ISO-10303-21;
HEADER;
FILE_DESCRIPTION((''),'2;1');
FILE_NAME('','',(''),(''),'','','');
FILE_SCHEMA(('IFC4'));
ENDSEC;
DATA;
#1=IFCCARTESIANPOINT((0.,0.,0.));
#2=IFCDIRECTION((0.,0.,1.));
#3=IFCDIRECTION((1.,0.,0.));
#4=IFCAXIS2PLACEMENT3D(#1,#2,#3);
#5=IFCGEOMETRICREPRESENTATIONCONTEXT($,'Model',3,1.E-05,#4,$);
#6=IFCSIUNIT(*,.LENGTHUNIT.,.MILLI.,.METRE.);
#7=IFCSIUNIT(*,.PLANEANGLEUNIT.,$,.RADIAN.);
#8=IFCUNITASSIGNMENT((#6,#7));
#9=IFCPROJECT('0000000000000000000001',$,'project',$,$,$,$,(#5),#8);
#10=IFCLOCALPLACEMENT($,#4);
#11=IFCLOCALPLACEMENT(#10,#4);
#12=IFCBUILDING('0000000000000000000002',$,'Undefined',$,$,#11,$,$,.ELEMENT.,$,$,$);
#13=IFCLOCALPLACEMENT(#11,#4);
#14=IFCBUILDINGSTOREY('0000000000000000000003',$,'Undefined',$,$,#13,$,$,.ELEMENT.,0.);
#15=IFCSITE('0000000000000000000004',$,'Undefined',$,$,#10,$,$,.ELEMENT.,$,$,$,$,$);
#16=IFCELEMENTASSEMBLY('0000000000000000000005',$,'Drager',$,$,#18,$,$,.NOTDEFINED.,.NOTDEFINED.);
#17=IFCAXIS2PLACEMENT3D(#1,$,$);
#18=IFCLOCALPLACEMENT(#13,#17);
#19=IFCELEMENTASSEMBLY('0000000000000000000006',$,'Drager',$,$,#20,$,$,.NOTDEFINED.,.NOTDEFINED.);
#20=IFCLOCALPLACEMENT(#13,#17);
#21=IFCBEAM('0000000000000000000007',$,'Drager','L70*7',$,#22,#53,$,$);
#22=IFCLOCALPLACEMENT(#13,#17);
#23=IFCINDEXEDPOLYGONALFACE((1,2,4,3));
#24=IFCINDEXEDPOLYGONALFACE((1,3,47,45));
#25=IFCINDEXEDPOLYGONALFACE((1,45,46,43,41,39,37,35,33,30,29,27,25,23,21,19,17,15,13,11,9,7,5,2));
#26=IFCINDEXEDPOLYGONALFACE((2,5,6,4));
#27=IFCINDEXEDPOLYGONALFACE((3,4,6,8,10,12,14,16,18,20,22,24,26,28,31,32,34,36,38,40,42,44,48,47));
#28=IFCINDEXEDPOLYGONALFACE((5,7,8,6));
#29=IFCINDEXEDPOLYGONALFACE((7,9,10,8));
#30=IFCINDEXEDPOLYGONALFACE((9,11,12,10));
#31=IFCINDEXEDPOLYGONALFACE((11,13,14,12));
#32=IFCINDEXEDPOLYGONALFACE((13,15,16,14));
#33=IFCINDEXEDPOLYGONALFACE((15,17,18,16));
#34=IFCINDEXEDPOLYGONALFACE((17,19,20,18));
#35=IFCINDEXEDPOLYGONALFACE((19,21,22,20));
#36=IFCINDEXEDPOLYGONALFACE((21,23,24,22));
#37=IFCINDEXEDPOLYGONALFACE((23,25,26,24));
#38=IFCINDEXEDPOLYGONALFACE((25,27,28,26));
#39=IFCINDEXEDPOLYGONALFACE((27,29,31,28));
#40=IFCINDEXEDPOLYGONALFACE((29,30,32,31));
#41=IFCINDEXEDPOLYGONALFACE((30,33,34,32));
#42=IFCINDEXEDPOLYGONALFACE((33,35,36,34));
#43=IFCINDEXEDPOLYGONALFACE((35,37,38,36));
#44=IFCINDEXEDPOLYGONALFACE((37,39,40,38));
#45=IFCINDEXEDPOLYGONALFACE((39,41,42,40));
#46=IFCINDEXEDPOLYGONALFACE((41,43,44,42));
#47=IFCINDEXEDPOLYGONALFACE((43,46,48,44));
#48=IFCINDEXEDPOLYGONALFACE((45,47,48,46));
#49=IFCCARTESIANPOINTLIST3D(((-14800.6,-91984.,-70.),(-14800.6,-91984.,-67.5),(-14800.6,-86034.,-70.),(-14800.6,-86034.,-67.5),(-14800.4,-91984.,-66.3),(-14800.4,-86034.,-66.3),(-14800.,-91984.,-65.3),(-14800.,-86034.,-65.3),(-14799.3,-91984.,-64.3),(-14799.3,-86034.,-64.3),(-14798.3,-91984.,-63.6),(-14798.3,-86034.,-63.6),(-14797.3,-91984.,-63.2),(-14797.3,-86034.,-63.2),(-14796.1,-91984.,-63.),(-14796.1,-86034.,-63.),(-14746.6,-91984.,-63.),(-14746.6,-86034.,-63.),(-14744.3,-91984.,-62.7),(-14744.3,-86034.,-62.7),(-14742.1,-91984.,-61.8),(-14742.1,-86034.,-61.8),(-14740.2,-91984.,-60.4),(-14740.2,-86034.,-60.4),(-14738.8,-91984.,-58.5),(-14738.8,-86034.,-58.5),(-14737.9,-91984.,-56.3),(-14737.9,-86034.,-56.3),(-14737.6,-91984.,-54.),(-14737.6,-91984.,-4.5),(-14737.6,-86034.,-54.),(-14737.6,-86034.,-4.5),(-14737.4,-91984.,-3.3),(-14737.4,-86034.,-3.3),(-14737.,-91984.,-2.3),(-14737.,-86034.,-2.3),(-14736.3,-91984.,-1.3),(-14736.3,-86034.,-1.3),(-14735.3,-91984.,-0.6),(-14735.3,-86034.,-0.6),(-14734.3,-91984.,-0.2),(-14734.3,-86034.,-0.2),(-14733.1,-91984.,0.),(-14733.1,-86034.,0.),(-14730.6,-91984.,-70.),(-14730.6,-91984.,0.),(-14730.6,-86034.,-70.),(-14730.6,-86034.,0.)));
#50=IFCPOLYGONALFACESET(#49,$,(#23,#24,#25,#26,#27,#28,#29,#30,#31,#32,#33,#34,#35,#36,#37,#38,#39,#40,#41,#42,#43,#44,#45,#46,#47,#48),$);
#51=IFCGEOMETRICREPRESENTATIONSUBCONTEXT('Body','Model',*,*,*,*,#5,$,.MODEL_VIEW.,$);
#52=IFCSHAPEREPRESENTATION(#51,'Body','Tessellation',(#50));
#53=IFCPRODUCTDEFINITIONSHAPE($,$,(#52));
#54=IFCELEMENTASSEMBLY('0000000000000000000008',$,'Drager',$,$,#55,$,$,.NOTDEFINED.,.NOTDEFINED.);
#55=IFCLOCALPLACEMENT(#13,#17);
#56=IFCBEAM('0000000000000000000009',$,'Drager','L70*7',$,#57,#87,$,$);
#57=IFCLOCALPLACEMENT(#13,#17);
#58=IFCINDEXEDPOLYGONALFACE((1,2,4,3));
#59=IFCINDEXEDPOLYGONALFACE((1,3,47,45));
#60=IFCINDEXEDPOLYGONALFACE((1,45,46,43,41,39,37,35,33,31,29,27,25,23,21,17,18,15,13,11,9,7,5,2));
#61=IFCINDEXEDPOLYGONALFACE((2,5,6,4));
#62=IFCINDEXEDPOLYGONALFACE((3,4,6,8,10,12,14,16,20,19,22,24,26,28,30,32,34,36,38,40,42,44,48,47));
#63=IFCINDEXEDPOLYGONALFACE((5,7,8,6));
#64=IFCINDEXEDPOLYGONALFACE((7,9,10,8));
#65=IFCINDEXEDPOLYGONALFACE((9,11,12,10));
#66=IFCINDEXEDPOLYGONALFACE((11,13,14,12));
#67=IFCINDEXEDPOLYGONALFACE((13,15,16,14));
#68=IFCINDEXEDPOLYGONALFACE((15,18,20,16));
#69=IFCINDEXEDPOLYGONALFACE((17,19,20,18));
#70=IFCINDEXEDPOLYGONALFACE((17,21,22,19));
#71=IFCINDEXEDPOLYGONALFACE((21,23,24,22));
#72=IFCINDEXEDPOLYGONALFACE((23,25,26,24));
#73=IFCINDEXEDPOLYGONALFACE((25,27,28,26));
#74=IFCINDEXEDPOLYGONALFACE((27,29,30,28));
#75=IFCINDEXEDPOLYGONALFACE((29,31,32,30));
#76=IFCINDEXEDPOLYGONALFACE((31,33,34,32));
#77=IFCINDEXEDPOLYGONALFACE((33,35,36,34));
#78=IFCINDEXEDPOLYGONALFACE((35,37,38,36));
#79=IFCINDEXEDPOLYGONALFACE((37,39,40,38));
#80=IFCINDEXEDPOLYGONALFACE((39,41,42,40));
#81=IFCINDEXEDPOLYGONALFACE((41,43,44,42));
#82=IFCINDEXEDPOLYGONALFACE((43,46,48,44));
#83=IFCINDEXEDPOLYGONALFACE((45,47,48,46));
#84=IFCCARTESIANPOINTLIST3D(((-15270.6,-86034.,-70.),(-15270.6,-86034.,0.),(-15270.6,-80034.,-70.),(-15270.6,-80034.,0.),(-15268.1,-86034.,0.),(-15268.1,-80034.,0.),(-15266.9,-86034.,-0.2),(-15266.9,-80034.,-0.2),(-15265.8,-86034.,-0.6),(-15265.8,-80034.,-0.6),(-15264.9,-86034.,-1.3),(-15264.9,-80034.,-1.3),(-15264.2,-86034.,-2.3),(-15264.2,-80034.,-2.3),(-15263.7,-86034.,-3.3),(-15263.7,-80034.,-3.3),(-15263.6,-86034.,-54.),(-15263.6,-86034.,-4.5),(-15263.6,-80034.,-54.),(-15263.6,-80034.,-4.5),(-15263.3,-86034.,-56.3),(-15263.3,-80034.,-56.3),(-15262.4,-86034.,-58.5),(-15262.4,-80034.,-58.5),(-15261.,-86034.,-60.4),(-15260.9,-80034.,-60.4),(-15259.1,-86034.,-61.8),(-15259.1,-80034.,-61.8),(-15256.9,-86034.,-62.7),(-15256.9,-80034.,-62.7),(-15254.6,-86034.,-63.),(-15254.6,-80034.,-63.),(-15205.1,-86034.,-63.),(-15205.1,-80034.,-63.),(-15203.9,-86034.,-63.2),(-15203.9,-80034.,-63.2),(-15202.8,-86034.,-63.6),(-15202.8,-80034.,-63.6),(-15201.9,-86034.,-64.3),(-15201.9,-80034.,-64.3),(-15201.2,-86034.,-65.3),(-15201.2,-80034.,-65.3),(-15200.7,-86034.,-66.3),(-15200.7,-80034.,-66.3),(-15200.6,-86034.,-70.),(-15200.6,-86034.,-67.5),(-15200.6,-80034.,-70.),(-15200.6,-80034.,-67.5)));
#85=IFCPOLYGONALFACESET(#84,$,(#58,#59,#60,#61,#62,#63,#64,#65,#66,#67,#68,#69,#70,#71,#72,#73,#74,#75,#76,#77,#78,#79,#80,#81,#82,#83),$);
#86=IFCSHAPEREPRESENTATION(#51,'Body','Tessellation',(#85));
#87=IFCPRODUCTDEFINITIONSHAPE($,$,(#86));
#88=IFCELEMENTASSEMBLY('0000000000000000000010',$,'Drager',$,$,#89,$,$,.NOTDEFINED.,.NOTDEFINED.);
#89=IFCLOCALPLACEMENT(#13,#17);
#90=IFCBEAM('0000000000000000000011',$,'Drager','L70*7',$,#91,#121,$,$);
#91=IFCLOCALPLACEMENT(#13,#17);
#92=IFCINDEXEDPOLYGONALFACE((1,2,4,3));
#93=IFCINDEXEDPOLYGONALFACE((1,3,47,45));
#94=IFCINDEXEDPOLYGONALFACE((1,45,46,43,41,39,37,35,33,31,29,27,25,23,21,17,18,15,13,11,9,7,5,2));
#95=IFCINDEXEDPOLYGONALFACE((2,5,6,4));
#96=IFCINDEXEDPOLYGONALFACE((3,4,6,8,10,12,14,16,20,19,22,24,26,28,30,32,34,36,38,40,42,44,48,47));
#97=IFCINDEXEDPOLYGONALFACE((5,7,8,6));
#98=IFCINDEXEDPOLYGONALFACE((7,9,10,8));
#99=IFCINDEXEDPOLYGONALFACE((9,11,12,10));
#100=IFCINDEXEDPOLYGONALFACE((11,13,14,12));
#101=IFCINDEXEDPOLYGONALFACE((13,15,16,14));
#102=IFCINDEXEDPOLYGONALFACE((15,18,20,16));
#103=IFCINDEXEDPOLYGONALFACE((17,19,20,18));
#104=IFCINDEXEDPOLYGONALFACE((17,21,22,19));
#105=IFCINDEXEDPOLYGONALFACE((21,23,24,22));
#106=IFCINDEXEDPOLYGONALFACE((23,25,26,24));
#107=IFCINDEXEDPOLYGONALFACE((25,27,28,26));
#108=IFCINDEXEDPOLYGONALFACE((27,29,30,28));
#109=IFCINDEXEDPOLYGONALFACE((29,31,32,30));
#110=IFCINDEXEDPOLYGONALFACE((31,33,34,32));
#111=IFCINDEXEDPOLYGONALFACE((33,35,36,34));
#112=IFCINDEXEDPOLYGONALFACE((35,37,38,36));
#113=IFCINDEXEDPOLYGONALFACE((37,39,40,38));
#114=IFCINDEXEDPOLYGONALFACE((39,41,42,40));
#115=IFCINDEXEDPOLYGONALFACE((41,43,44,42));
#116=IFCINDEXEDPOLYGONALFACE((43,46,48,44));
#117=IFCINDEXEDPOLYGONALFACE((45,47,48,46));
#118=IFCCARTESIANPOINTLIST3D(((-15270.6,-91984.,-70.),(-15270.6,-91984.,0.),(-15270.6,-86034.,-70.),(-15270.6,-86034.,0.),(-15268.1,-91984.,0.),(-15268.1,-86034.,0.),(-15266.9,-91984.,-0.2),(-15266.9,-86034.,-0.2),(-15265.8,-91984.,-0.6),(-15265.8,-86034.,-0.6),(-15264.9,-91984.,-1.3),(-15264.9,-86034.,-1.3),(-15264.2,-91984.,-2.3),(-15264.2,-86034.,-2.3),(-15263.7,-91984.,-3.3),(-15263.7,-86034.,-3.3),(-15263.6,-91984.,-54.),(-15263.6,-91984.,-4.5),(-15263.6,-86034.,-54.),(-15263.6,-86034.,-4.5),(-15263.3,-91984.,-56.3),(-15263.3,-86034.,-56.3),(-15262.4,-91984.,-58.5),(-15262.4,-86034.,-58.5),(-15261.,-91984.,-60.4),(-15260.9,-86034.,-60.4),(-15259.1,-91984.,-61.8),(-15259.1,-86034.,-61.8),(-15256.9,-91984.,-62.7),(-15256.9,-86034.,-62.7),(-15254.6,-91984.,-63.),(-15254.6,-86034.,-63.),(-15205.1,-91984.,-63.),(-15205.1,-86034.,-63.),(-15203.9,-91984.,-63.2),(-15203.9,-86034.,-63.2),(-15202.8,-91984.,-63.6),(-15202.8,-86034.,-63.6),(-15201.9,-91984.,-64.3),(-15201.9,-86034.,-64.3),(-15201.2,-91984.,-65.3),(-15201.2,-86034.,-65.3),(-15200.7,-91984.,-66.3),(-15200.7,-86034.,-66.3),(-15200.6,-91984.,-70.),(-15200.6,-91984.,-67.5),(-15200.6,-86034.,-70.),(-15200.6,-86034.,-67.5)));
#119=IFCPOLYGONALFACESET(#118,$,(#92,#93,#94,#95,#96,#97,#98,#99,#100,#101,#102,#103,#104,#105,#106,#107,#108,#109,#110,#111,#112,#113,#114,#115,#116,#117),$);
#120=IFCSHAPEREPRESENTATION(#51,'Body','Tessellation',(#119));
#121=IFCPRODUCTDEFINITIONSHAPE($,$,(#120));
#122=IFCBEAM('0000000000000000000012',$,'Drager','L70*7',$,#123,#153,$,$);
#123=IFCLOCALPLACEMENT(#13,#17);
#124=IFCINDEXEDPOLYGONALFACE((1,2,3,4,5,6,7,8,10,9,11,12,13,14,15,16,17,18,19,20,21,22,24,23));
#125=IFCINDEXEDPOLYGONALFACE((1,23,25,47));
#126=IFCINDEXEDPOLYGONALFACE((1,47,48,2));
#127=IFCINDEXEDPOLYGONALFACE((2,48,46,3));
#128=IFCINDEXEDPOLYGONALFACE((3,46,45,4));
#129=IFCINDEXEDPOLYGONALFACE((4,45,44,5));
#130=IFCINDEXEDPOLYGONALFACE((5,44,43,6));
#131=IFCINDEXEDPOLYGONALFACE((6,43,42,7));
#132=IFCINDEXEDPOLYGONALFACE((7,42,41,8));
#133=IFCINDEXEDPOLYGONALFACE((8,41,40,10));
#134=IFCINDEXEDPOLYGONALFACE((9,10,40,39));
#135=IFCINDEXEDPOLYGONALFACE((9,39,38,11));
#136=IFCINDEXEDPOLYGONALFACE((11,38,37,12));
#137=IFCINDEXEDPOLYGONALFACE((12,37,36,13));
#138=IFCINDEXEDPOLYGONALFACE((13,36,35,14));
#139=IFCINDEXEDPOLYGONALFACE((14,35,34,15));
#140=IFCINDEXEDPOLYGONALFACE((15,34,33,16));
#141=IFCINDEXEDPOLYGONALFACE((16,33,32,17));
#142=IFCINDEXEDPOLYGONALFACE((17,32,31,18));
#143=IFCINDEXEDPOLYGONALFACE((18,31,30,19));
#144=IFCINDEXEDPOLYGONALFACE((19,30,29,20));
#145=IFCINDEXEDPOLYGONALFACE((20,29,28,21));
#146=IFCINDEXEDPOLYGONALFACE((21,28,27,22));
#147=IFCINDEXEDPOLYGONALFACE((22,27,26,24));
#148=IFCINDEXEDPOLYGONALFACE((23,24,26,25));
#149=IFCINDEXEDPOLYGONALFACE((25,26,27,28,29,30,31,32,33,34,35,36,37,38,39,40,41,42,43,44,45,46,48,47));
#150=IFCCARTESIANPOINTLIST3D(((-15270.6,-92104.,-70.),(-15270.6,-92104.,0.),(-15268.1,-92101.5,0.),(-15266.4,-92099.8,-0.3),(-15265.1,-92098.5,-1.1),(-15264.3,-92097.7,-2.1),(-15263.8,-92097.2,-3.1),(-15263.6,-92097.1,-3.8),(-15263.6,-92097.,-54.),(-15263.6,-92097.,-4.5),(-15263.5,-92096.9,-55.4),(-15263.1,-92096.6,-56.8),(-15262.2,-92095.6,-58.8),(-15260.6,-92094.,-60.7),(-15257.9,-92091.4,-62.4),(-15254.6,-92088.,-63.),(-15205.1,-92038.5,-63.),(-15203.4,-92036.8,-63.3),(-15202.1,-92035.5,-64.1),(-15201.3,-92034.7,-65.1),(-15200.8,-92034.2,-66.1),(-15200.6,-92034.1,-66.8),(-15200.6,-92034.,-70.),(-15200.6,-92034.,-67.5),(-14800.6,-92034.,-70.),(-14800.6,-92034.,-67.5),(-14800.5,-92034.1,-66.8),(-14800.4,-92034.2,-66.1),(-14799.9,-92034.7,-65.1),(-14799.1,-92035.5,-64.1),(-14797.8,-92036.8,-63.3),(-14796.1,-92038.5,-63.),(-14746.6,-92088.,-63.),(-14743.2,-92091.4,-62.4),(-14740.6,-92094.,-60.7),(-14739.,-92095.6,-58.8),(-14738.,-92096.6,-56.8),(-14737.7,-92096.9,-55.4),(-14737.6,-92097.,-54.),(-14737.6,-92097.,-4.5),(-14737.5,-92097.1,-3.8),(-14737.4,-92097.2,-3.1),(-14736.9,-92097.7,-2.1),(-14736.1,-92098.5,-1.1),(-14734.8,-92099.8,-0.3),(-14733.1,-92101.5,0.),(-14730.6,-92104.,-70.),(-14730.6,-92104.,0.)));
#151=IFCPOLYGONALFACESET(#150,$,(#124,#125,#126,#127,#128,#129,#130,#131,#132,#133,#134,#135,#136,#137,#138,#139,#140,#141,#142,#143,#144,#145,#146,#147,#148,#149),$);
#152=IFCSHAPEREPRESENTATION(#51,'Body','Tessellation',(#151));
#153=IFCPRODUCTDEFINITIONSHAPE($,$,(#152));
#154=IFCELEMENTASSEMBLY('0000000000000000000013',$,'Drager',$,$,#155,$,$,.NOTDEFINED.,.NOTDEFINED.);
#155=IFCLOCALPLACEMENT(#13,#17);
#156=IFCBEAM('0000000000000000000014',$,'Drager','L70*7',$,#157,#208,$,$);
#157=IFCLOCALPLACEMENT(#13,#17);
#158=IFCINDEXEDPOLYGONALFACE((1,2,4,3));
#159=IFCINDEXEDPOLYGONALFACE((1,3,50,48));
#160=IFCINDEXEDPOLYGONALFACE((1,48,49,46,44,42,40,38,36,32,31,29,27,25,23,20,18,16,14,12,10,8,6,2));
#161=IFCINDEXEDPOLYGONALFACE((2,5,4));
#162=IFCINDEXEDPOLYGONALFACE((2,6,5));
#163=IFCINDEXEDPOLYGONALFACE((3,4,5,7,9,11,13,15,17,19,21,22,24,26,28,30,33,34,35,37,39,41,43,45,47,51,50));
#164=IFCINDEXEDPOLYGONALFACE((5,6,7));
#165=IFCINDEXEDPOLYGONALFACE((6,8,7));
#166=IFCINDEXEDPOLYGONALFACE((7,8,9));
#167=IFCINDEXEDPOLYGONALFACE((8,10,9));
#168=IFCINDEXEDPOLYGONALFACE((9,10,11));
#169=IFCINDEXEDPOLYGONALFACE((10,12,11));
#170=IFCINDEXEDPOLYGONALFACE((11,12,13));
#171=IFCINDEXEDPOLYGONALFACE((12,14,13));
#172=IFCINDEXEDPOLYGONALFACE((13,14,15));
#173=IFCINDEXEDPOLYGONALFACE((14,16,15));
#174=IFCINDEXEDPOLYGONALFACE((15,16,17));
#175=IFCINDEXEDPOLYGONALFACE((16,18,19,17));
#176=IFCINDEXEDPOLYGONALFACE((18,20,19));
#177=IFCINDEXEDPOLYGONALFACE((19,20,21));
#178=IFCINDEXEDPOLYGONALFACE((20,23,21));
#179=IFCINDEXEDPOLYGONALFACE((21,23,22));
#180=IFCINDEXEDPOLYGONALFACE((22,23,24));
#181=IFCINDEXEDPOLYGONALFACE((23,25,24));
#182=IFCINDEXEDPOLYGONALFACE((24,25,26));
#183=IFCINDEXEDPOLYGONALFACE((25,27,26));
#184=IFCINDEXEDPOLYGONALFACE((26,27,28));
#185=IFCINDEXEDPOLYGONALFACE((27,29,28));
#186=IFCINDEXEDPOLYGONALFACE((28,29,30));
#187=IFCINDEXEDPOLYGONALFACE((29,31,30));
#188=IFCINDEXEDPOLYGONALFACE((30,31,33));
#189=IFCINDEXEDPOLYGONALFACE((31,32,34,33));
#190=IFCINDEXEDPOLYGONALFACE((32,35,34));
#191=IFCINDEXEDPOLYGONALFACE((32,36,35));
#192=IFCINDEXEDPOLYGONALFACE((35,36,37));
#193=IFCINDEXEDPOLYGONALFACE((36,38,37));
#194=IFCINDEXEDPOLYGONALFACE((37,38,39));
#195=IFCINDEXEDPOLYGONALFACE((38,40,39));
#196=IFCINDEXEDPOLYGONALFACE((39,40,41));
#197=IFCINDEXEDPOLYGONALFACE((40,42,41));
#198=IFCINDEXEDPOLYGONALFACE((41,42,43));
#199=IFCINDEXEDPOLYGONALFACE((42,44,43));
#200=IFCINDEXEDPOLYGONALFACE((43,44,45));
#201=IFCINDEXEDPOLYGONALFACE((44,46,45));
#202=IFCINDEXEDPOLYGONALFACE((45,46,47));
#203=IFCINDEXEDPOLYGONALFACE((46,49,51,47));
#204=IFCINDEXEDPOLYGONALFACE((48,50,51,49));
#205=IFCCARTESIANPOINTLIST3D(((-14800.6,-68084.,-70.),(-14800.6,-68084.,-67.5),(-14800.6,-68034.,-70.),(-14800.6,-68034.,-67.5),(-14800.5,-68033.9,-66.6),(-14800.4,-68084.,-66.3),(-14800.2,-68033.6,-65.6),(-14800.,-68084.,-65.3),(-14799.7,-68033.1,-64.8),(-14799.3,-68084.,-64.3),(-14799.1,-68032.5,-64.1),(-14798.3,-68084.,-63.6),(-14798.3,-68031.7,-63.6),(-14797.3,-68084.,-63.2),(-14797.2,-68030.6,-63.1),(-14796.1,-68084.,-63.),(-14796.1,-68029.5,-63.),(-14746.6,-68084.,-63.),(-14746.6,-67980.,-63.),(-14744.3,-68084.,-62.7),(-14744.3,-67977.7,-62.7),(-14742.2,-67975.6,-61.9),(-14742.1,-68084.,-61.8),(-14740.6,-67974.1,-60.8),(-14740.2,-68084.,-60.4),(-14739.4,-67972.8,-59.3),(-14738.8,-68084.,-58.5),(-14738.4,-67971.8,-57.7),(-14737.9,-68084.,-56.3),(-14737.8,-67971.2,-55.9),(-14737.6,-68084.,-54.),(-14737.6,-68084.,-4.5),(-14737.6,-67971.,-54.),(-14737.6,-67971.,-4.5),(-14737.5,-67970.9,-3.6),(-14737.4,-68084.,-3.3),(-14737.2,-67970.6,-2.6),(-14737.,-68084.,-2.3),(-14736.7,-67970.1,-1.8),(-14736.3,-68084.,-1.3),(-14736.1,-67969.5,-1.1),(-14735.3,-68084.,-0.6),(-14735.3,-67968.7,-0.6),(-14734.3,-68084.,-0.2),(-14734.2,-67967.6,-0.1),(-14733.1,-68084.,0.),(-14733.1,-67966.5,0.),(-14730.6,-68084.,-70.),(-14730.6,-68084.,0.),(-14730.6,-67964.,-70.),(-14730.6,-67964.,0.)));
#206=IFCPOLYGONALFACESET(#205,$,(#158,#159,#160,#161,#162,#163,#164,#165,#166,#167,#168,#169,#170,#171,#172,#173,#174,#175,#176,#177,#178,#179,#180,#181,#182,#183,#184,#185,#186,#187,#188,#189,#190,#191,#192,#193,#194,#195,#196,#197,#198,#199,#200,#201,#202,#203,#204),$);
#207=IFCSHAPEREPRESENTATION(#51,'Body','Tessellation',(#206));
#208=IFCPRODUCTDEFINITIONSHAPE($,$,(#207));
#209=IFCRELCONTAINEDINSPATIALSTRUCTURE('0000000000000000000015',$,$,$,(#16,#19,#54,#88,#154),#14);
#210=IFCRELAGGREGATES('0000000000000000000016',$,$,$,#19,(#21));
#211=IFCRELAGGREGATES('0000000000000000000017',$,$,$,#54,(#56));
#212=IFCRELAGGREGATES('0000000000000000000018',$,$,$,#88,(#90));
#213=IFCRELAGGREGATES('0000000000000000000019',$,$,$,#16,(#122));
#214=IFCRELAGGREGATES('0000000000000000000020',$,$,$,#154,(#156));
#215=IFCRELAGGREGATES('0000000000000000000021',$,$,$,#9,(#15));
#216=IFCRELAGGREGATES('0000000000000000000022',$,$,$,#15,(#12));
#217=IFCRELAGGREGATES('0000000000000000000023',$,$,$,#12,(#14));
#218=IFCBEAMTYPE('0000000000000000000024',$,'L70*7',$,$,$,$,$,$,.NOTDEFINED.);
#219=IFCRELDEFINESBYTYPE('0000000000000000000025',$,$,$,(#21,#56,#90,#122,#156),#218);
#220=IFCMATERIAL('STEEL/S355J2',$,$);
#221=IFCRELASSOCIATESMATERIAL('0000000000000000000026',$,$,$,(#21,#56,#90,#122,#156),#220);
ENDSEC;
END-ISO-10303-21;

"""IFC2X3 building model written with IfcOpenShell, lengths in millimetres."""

from ifc_helpers import new_model, si_unit, frame, origin_with_axes, origin_2d_with_axis, place, context, subcontext, project, spatial, l_section, extrude, clip, halfspace, material, type_object, element, aggregate, save


model = new_model("IFC2X3")

# Units and contexts
model_context = context("Model", 3, precision=1e-05, world=origin_with_axes())
body_context = subcontext(model_context, "Body", "Model", "MODEL_VIEW")
ifc_project = project(units=[si_unit("LENGTHUNIT", "METRE", prefix="MILLI"), si_unit("PLANEANGLEUNIT", "RADIAN")], contexts=[model_context])

# Site, building, storey
site_placement = place(None, origin_with_axes())
site = spatial("IfcSite", under=ifc_project, at=site_placement, Name="Undefined", CompositionType="ELEMENT")
building_placement = place(site_placement, origin_with_axes())
building = spatial("IfcBuilding", under=site, at=building_placement, Name="Undefined", CompositionType="ELEMENT")
storey_placement = place(building_placement, origin_with_axes())
storey = spatial("IfcBuildingStorey", under=building, at=storey_placement, Name="Undefined", CompositionType="ELEMENT", Elevation=0.0)

# Shared definitions
ifc_material = material(Name="STEEL/S355J2")
beam_type = type_object("IfcBeamType", Name="L70*7", PredefinedType="NOTDEFINED")

# Element assembly
assembly_1_placement = place(storey_placement, origin_with_axes())
assembly_1 = element("IfcElementAssembly", 1, at=assembly_1_placement, inside=storey, Name="Drager", AssemblyPlace="NOTDEFINED", PredefinedType="NOTDEFINED")

# Element assemblies, beams
assembly_2_placement = place(storey_placement, origin_with_axes())
assembly_2 = element("IfcElementAssembly", 2, at=assembly_2_placement, inside=storey, Name="Drager", AssemblyPlace="NOTDEFINED", PredefinedType="NOTDEFINED")
beam_1_placement = place(assembly_2_placement, frame((-14765.6, -86034.0, -35.0), z_axis=(0.0, 0.0, 1.0), x_axis=(0.0, -1.0, 0.0)))
beam_1 = element("IfcBeam", 3, at=beam_1_placement, type_object=beam_type, material=ifc_material, Name="Drager", Description="L70*7", context=body_context, shape_type="SweptSolid", body=[
    extrude(l_section(Depth=70.0, Width=70.0, Thickness=7.0, FilletRadius=9.0, EdgeRadius=4.5, at=origin_2d_with_axis()), frame((5950.0, 0.0, 0.0), z_axis=(-1.0, 0.0, 0.0), x_axis=(0.0, -1.0, 0.0)), (0.0, 0.0, 1.0), 5950.0),
])
aggregate(assembly_2, [beam_1])
assembly_3_placement = place(storey_placement, origin_with_axes())
assembly_3 = element("IfcElementAssembly", 4, at=assembly_3_placement, inside=storey, Name="Drager", AssemblyPlace="NOTDEFINED", PredefinedType="NOTDEFINED")
beam_2_placement = place(assembly_3_placement, frame((-15235.6, -86034.0, -35.0), z_axis=(0.0, 0.0, 1.0), x_axis=(0.0, 1.0, 0.0)))
beam_2 = element("IfcBeam", 5, at=beam_2_placement, type_object=beam_type, material=ifc_material, Name="Drager", Description="L70*7", context=body_context, shape_type="SweptSolid", body=[
    extrude(l_section(Depth=70.0, Width=70.0, Thickness=7.0, FilletRadius=9.0, EdgeRadius=4.5, at=origin_2d_with_axis()), frame((6000.0, 0.0, 0.0), z_axis=(-1.0, 0.0, 0.0), x_axis=(0.0, -1.0, 0.0)), (0.0, 0.0, 1.0), 6000.0),
])
aggregate(assembly_3, [beam_2])
assembly_4_placement = place(storey_placement, origin_with_axes())
assembly_4 = element("IfcElementAssembly", 6, at=assembly_4_placement, inside=storey, Name="Drager", AssemblyPlace="NOTDEFINED", PredefinedType="NOTDEFINED")
beam_3_placement = place(assembly_4_placement, frame((-15235.6, -91984.0, -35.0), z_axis=(0.0, 0.0, 1.0), x_axis=(0.0, 1.0, 0.0)))
beam_3 = element("IfcBeam", 7, at=beam_3_placement, type_object=beam_type, material=ifc_material, Name="Drager", Description="L70*7", context=body_context, shape_type="SweptSolid", body=[
    extrude(l_section(Depth=70.0, Width=70.0, Thickness=7.0, FilletRadius=9.0, EdgeRadius=4.5, at=origin_2d_with_axis()), frame((5950.0, 0.0, 0.0), z_axis=(-1.0, 0.0, 0.0), x_axis=(0.0, -1.0, 0.0)), (0.0, 0.0, 1.0), 5950.0),
])
aggregate(assembly_4, [beam_3])

# Beam
beam_4_placement = place(assembly_1_placement, frame((-14800.6, -92069.0, -35.0), z_axis=(0.0, 0.0, 1.0), x_axis=(-1.0, 0.0, 0.0)))
beam_4 = element("IfcBeam", 8, at=beam_4_placement, type_object=beam_type, material=ifc_material, Name="Drager", Description="L70*7", context=body_context, shape_type="Clipping", body=[
    clip(clip(extrude(l_section(Depth=70.0, Width=70.0, Thickness=7.0, FilletRadius=9.0, EdgeRadius=4.5, at=origin_2d_with_axis()), frame((505.7, 0.0, 0.0), z_axis=(-1.0, 0.0, 0.0), x_axis=(0.0, -1.0, 0.0)), (0.0, 0.0, 1.0), 611.4), halfspace(frame((400.0, -35.0, 35.0), z_axis=(0.707107, -0.707107, 0.0), x_axis=(0.0, 0.0, 1.0)), False)), halfspace(frame((0.0, -35.0, 35.0), z_axis=(0.707107, 0.707107, 0.0), x_axis=(0.0, 0.0, 1.0)), True)),
])
aggregate(assembly_1, [beam_4])

# Element assembly, beam
assembly_5_placement = place(storey_placement, origin_with_axes())
assembly_5 = element("IfcElementAssembly", 9, at=assembly_5_placement, inside=storey, Name="Drager", AssemblyPlace="NOTDEFINED", PredefinedType="NOTDEFINED")
beam_5_placement = place(assembly_5_placement, frame((-14765.6, -68034.0, -35.0), z_axis=(0.0, 0.0, 1.0), x_axis=(0.0, -1.0, 0.0)))
beam_5 = element("IfcBeam", 10, at=beam_5_placement, type_object=beam_type, material=ifc_material, Name="Drager", Description="L70*7", context=body_context, shape_type="Clipping", body=[
    clip(extrude(l_section(Depth=70.0, Width=70.0, Thickness=7.0, FilletRadius=9.0, EdgeRadius=4.5, at=origin_2d_with_axis()), frame((50.0, 0.0, 0.0), z_axis=(-1.0, 0.0, 0.0), x_axis=(0.0, -1.0, 0.0)), (0.0, 0.0, 1.0), 120.3), halfspace(frame((0.0, -35.0, 35.0), z_axis=(-0.707107, -0.707107, 0.0), x_axis=(-0.707107, 0.707107, 0.0)), False)),
])
aggregate(assembly_5, [beam_5])

save(model, "model.ifc")
